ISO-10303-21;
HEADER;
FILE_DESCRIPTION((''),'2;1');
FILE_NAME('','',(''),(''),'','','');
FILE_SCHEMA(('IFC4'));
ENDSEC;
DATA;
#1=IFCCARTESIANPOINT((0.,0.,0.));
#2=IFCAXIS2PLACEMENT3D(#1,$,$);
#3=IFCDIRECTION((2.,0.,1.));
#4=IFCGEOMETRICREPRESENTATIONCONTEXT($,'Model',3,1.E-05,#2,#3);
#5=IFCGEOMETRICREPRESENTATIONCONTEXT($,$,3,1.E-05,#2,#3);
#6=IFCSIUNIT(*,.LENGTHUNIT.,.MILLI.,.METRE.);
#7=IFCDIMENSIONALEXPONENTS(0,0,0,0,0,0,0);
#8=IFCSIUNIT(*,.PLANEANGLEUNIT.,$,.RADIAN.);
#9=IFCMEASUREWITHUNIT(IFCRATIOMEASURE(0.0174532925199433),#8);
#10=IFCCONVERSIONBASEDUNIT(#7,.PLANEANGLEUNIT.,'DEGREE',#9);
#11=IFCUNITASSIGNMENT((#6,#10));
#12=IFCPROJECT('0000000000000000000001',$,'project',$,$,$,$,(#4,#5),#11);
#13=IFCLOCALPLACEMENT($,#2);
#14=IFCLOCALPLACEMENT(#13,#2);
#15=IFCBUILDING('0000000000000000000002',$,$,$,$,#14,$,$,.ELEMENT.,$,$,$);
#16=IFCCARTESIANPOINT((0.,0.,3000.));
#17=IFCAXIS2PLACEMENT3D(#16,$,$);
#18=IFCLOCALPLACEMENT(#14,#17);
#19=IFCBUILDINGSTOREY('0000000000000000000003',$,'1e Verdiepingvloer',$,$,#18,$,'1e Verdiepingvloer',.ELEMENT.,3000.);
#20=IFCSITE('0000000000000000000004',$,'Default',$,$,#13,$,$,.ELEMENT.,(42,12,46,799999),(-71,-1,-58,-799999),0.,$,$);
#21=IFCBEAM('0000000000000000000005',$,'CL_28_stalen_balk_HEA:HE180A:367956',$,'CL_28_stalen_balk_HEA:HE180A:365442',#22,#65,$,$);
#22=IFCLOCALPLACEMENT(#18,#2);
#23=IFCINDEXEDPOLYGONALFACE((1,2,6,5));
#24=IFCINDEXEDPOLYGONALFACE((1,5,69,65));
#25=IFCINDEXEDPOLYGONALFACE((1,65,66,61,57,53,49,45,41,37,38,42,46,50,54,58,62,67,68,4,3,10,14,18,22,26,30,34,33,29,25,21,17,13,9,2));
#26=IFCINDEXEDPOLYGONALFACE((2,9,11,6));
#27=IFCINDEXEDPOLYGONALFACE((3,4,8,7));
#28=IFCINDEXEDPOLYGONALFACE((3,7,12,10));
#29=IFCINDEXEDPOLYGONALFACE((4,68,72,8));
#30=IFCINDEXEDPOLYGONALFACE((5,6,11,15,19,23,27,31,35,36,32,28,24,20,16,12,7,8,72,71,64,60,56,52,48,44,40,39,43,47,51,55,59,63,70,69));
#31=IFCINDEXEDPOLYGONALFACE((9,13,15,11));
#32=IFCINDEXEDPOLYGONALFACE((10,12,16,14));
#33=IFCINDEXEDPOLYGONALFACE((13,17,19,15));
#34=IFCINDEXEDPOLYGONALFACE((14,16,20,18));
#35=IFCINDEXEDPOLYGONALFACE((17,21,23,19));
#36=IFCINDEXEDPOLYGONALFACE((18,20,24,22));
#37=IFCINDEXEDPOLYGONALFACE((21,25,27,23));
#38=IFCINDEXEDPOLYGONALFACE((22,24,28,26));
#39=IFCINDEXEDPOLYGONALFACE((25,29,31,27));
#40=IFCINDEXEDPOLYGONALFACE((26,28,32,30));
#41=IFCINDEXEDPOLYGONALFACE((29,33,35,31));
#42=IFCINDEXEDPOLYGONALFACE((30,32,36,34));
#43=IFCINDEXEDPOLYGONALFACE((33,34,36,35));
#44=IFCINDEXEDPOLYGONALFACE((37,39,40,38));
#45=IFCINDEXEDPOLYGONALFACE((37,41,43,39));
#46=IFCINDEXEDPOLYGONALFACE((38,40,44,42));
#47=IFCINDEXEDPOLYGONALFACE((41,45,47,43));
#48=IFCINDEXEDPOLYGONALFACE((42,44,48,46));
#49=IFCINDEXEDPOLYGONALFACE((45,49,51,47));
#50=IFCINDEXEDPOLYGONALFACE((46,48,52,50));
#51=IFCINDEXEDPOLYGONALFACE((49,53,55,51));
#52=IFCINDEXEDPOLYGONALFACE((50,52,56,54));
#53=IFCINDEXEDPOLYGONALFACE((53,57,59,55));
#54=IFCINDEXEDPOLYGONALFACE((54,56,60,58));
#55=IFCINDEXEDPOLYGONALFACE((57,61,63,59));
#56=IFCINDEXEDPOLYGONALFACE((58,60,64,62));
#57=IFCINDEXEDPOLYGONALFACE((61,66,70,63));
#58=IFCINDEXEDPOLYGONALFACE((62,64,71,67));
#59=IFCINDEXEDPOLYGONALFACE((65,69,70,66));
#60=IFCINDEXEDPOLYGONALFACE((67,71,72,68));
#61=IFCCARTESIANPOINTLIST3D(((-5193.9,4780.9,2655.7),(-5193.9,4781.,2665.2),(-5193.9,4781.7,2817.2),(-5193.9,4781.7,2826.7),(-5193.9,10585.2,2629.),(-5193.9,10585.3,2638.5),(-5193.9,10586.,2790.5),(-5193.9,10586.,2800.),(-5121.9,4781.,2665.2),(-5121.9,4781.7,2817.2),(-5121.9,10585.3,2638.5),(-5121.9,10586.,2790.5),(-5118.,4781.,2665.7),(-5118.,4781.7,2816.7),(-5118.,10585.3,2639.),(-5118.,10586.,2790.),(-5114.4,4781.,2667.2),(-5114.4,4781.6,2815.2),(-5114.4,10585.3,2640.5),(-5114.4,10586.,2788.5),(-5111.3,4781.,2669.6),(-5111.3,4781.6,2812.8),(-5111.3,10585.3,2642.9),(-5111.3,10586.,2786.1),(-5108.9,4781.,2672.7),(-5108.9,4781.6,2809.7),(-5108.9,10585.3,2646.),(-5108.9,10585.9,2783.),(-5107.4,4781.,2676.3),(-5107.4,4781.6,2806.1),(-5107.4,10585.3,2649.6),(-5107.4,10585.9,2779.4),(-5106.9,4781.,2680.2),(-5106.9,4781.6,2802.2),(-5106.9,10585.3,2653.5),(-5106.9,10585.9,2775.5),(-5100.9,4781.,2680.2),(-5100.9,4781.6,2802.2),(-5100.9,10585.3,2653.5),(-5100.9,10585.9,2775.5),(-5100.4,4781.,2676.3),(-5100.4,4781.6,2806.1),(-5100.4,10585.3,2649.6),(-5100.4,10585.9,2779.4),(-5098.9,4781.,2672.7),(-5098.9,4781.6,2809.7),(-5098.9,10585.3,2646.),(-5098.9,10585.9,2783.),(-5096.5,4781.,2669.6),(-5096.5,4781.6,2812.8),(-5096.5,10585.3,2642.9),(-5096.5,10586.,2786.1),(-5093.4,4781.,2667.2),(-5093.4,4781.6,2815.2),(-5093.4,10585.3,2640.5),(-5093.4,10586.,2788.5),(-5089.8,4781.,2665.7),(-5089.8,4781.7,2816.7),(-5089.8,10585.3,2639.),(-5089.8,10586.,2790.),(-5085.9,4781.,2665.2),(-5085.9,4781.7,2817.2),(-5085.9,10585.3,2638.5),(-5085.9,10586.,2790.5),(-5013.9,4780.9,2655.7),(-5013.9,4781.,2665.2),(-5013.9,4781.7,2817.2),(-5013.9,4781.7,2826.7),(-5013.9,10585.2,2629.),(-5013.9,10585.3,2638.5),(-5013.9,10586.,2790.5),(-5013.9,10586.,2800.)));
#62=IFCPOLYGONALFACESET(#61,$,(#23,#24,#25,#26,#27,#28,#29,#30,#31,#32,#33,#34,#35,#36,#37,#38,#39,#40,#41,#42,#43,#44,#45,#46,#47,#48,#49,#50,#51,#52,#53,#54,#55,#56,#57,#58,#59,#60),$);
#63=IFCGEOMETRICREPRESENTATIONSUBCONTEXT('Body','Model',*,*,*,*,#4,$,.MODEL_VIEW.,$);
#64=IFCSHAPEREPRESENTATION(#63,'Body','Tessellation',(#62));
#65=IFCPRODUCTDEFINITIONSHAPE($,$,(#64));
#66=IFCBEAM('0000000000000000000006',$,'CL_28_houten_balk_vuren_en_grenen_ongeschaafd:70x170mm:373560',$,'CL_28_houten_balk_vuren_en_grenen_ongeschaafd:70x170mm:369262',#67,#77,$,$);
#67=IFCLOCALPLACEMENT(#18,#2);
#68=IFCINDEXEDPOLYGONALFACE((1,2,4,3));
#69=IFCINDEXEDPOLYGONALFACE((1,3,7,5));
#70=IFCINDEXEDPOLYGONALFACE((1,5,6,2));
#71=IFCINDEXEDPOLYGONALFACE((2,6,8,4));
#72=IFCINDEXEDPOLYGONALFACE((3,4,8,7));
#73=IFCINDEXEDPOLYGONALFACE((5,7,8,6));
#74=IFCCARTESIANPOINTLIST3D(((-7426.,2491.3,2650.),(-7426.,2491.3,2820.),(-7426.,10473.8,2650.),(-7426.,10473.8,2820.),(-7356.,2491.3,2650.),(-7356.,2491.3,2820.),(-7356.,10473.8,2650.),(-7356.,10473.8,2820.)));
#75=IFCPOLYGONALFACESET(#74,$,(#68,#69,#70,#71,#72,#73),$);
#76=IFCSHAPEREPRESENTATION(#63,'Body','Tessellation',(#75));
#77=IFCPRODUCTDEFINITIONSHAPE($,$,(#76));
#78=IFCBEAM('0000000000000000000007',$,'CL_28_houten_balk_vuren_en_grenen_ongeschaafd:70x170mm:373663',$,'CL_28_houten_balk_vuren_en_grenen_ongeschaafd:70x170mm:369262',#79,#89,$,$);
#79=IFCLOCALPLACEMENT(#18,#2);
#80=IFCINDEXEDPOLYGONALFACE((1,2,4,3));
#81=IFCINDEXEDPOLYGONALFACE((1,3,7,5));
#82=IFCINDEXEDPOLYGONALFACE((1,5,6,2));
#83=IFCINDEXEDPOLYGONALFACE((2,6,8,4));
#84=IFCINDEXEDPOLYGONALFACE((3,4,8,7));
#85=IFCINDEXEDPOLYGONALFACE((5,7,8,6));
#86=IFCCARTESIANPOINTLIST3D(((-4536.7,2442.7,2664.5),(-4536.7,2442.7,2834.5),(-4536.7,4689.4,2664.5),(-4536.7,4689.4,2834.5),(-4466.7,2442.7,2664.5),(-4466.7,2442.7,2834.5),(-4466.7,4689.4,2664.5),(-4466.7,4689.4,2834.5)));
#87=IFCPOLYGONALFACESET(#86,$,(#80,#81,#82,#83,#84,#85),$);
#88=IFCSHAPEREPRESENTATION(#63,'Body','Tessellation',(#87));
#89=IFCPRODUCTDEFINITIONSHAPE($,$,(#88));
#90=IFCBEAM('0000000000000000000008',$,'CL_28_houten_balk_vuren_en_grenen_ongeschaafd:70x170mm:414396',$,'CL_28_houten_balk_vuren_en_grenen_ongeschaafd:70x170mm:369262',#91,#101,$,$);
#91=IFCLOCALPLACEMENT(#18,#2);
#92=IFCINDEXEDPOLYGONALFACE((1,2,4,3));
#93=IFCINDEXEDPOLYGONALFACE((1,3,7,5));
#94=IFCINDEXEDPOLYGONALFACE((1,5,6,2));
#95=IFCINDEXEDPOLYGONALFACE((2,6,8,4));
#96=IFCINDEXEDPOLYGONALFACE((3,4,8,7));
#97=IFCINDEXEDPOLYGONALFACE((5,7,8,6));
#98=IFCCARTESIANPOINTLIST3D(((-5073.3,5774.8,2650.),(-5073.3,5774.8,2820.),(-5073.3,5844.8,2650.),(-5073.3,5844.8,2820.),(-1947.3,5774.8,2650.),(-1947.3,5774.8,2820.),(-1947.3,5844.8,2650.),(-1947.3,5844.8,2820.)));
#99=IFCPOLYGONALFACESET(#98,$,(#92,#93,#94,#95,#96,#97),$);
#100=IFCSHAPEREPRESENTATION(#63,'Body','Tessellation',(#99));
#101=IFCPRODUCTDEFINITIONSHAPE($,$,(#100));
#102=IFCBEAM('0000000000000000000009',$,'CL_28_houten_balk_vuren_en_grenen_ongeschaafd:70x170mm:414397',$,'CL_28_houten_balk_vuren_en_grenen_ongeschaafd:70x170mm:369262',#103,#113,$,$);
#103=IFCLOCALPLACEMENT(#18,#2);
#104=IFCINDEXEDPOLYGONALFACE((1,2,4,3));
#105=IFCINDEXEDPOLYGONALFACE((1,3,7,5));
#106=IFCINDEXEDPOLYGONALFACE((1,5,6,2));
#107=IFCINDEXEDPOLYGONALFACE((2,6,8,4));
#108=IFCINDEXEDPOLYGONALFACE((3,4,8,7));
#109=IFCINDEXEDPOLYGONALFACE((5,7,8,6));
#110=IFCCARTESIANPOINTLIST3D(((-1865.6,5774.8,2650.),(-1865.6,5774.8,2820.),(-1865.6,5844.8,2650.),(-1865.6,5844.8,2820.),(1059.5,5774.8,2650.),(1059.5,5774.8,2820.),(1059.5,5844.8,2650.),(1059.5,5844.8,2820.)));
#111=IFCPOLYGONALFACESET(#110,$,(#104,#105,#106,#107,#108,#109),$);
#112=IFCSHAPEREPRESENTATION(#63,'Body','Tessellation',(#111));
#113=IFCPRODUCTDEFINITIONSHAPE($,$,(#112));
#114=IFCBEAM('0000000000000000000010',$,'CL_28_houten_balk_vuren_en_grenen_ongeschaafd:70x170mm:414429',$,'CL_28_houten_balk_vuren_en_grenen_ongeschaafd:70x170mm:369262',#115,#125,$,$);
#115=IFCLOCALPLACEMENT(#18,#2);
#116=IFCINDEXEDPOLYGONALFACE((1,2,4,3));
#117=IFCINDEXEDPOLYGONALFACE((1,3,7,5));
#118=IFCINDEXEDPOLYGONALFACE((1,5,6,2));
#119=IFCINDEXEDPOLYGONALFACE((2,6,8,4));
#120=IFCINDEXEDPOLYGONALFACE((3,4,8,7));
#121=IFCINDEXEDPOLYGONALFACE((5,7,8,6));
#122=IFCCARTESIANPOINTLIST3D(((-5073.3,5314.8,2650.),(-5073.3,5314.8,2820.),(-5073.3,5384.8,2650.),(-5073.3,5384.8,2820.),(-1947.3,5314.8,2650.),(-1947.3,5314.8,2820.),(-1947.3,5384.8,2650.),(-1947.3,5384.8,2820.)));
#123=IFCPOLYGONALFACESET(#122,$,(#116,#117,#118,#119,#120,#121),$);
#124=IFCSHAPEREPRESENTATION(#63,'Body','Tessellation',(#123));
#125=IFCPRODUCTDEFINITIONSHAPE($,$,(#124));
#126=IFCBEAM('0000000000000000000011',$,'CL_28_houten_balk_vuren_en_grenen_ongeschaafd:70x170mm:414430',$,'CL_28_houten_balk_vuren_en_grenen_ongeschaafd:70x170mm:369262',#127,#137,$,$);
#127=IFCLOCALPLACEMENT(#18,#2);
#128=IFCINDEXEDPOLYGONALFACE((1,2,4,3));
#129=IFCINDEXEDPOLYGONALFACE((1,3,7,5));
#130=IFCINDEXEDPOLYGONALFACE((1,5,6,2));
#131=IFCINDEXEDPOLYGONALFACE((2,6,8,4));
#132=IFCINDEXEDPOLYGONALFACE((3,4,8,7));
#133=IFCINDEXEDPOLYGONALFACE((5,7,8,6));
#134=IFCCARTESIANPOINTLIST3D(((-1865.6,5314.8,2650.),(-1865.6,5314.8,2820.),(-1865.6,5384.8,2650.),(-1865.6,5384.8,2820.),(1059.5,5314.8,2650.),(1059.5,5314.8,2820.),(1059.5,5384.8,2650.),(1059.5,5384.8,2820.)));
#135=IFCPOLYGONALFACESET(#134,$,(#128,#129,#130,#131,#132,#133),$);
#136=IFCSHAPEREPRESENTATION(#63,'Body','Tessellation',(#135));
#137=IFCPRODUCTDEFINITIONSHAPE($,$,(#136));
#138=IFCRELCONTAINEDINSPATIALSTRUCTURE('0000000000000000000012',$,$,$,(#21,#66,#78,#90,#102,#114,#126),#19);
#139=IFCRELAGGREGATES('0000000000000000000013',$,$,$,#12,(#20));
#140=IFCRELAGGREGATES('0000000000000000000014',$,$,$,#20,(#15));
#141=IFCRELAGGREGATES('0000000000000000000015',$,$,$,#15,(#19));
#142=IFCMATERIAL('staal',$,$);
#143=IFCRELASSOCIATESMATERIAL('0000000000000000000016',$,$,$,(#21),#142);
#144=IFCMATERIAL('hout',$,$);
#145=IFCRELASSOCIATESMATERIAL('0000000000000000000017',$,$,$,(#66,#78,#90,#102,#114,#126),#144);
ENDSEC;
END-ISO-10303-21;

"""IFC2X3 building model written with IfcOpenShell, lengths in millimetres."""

from ifc_helpers import new_model, entity, si_unit, converted_unit, direction, frame, frame_2d, origin, place, context, subcontext, project, spatial, rectangle, i_section, extrude, material, element, save


model = new_model("IFC2X3")

# Units and contexts
model_context = context("Model", 3, precision=1e-05, world=origin(), true_north=direction((2.0, 0.0, 1.0)))
context_of_model = context(None, 3, precision=1e-05, world=origin(), true_north=direction((2.0, 0.0, 1.0)))
body_context = subcontext(model_context, "Body", "Model", "MODEL_VIEW")
ifc_project = project(units=[si_unit("LENGTHUNIT", "METRE", prefix="MILLI"), converted_unit("PLANEANGLEUNIT", "DEGREE", entity("IfcRatioMeasure", 0.0174532925199433), si_unit("PLANEANGLEUNIT", "RADIAN"), dimensions=[0, 0, 0, 0, 0, 0, 0])], contexts=[model_context, context_of_model])

# Site, building, storey
site_placement = place(None, origin())
site = spatial("IfcSite", under=ifc_project, at=site_placement, Name="Default", CompositionType="ELEMENT", RefLatitude=(42, 12, 46, 799999), RefLongitude=(-71, -1, -58, -799999), RefElevation=0.0)
building_placement = place(site_placement, origin())
building = spatial("IfcBuilding", under=site, at=building_placement, CompositionType="ELEMENT")
storey_placement = place(building_placement, frame((0.0, 0.0, 3000.0)))
storey = spatial("IfcBuildingStorey", under=building, at=storey_placement, Name="1e Verdiepingvloer", LongName="1e Verdiepingvloer", CompositionType="ELEMENT", Elevation=3000.0)

# Beams
ifc_material_1 = material(Name="staal")
beam_1_placement = place(storey_placement, frame((-5103.9, 4939.9, 2826.0), z_axis=(0.0, 0.00461, 0.999989), x_axis=(0.0, 0.999989, -0.00461)))
element("IfcBeam", 1, at=beam_1_placement, inside=storey, material=ifc_material_1, Name="CL_28_stalen_balk_HEA:HE180A:367956", ObjectType="CL_28_stalen_balk_HEA:HE180A:365442", context=body_context, shape_type="SweptSolid", body=[
    extrude(i_section(OverallWidth=180.0, OverallDepth=171.0, WebThickness=6.0, FlangeThickness=9.5, FilletRadius=15.0, at=frame_2d((0.0, 0.0), x_axis=(0.0, 1.0))), frame((-158.2, 0.0, -85.5), z_axis=(1.0, 0.0, 0.0), x_axis=(0.0, 0.0, -1.0)), (0.0, 0.0, 1.0), 5804.4),
])
ifc_material_2 = material(Name="hout")
beam_2_placement = place(storey_placement, frame((-7391.0, 2480.8, 2820.0), z_axis=(0.0, 0.0, 1.0), x_axis=(0.0, 1.0, 0.0)))
element("IfcBeam", 2, at=beam_2_placement, inside=storey, material=ifc_material_2, Name="CL_28_houten_balk_vuren_en_grenen_ongeschaafd:70x170mm:373560", ObjectType="CL_28_houten_balk_vuren_en_grenen_ongeschaafd:70x170mm:369262", context=body_context, shape_type="SweptSolid", body=[
    extrude(rectangle(XDim=170.0, YDim=70.0, at=frame_2d((0.0, 0.0), x_axis=(1.0, 0.0))), frame((10.5, 0.0, -85.0), z_axis=(1.0, 0.0, 0.0), x_axis=(0.0, 0.0, -1.0)), (0.0, 0.0, 1.0), 7982.5),
])
beam_3_placement = place(storey_placement, frame((-4501.7, 2480.8, 2834.5), z_axis=(0.0, 0.0, 1.0), x_axis=(0.0, 1.0, 0.0)))
element("IfcBeam", 3, at=beam_3_placement, inside=storey, material=ifc_material_2, Name="CL_28_houten_balk_vuren_en_grenen_ongeschaafd:70x170mm:373663", ObjectType="CL_28_houten_balk_vuren_en_grenen_ongeschaafd:70x170mm:369262", context=body_context, shape_type="SweptSolid", body=[
    extrude(rectangle(XDim=170.0, YDim=70.0, at=frame_2d((0.0, 0.0), x_axis=(1.0, 0.0))), frame((-38.1, 0.0, -85.0), z_axis=(1.0, 0.0, 0.0), x_axis=(0.0, 0.0, -1.0)), (0.0, 0.0, 1.0), 2246.7),
])
beam_4_placement = place(storey_placement, frame((-5228.9, 5809.8, 2820.0)))
element("IfcBeam", 4, at=beam_4_placement, inside=storey, material=ifc_material_2, Name="CL_28_houten_balk_vuren_en_grenen_ongeschaafd:70x170mm:414396", ObjectType="CL_28_houten_balk_vuren_en_grenen_ongeschaafd:70x170mm:369262", context=body_context, shape_type="SweptSolid", body=[
    extrude(rectangle(XDim=170.0, YDim=70.0, at=frame_2d((0.0, 0.0), x_axis=(1.0, 0.0))), frame((155.6, 0.0, -85.0), z_axis=(1.0, 0.0, 0.0), x_axis=(0.0, 0.0, -1.0)), (0.0, 0.0, 1.0), 3126.0),
])
beam_5_placement = place(storey_placement, frame((-2128.9, 5809.8, 2820.0)))
element("IfcBeam", 5, at=beam_5_placement, inside=storey, material=ifc_material_2, Name="CL_28_houten_balk_vuren_en_grenen_ongeschaafd:70x170mm:414397", ObjectType="CL_28_houten_balk_vuren_en_grenen_ongeschaafd:70x170mm:369262", context=body_context, shape_type="SweptSolid", body=[
    extrude(rectangle(XDim=170.0, YDim=70.0, at=frame_2d((0.0, 0.0), x_axis=(1.0, 0.0))), frame((263.4, 0.0, -85.0), z_axis=(1.0, 0.0, 0.0), x_axis=(0.0, 0.0, -1.0)), (0.0, 0.0, 1.0), 2925.0),
])
beam_6_placement = place(storey_placement, frame((-5228.9, 5349.8, 2820.0)))
element("IfcBeam", 6, at=beam_6_placement, inside=storey, material=ifc_material_2, Name="CL_28_houten_balk_vuren_en_grenen_ongeschaafd:70x170mm:414429", ObjectType="CL_28_houten_balk_vuren_en_grenen_ongeschaafd:70x170mm:369262", context=body_context, shape_type="SweptSolid", body=[
    extrude(rectangle(XDim=170.0, YDim=70.0, at=frame_2d((0.0, 0.0), x_axis=(1.0, 0.0))), frame((155.6, 0.0, -85.0), z_axis=(1.0, 0.0, 0.0), x_axis=(0.0, 0.0, -1.0)), (0.0, 0.0, 1.0), 3126.0),
])
beam_7_placement = place(storey_placement, frame((-2128.9, 5349.8, 2820.0)))
element("IfcBeam", 7, at=beam_7_placement, inside=storey, material=ifc_material_2, Name="CL_28_houten_balk_vuren_en_grenen_ongeschaafd:70x170mm:414430", ObjectType="CL_28_houten_balk_vuren_en_grenen_ongeschaafd:70x170mm:369262", context=body_context, shape_type="SweptSolid", body=[
    extrude(rectangle(XDim=170.0, YDim=70.0, at=frame_2d((0.0, 0.0), x_axis=(1.0, 0.0))), frame((263.4, 0.0, -85.0), z_axis=(1.0, 0.0, 0.0), x_axis=(0.0, 0.0, -1.0)), (0.0, 0.0, 1.0), 2925.0),
])

save(model, "model.ifc")
